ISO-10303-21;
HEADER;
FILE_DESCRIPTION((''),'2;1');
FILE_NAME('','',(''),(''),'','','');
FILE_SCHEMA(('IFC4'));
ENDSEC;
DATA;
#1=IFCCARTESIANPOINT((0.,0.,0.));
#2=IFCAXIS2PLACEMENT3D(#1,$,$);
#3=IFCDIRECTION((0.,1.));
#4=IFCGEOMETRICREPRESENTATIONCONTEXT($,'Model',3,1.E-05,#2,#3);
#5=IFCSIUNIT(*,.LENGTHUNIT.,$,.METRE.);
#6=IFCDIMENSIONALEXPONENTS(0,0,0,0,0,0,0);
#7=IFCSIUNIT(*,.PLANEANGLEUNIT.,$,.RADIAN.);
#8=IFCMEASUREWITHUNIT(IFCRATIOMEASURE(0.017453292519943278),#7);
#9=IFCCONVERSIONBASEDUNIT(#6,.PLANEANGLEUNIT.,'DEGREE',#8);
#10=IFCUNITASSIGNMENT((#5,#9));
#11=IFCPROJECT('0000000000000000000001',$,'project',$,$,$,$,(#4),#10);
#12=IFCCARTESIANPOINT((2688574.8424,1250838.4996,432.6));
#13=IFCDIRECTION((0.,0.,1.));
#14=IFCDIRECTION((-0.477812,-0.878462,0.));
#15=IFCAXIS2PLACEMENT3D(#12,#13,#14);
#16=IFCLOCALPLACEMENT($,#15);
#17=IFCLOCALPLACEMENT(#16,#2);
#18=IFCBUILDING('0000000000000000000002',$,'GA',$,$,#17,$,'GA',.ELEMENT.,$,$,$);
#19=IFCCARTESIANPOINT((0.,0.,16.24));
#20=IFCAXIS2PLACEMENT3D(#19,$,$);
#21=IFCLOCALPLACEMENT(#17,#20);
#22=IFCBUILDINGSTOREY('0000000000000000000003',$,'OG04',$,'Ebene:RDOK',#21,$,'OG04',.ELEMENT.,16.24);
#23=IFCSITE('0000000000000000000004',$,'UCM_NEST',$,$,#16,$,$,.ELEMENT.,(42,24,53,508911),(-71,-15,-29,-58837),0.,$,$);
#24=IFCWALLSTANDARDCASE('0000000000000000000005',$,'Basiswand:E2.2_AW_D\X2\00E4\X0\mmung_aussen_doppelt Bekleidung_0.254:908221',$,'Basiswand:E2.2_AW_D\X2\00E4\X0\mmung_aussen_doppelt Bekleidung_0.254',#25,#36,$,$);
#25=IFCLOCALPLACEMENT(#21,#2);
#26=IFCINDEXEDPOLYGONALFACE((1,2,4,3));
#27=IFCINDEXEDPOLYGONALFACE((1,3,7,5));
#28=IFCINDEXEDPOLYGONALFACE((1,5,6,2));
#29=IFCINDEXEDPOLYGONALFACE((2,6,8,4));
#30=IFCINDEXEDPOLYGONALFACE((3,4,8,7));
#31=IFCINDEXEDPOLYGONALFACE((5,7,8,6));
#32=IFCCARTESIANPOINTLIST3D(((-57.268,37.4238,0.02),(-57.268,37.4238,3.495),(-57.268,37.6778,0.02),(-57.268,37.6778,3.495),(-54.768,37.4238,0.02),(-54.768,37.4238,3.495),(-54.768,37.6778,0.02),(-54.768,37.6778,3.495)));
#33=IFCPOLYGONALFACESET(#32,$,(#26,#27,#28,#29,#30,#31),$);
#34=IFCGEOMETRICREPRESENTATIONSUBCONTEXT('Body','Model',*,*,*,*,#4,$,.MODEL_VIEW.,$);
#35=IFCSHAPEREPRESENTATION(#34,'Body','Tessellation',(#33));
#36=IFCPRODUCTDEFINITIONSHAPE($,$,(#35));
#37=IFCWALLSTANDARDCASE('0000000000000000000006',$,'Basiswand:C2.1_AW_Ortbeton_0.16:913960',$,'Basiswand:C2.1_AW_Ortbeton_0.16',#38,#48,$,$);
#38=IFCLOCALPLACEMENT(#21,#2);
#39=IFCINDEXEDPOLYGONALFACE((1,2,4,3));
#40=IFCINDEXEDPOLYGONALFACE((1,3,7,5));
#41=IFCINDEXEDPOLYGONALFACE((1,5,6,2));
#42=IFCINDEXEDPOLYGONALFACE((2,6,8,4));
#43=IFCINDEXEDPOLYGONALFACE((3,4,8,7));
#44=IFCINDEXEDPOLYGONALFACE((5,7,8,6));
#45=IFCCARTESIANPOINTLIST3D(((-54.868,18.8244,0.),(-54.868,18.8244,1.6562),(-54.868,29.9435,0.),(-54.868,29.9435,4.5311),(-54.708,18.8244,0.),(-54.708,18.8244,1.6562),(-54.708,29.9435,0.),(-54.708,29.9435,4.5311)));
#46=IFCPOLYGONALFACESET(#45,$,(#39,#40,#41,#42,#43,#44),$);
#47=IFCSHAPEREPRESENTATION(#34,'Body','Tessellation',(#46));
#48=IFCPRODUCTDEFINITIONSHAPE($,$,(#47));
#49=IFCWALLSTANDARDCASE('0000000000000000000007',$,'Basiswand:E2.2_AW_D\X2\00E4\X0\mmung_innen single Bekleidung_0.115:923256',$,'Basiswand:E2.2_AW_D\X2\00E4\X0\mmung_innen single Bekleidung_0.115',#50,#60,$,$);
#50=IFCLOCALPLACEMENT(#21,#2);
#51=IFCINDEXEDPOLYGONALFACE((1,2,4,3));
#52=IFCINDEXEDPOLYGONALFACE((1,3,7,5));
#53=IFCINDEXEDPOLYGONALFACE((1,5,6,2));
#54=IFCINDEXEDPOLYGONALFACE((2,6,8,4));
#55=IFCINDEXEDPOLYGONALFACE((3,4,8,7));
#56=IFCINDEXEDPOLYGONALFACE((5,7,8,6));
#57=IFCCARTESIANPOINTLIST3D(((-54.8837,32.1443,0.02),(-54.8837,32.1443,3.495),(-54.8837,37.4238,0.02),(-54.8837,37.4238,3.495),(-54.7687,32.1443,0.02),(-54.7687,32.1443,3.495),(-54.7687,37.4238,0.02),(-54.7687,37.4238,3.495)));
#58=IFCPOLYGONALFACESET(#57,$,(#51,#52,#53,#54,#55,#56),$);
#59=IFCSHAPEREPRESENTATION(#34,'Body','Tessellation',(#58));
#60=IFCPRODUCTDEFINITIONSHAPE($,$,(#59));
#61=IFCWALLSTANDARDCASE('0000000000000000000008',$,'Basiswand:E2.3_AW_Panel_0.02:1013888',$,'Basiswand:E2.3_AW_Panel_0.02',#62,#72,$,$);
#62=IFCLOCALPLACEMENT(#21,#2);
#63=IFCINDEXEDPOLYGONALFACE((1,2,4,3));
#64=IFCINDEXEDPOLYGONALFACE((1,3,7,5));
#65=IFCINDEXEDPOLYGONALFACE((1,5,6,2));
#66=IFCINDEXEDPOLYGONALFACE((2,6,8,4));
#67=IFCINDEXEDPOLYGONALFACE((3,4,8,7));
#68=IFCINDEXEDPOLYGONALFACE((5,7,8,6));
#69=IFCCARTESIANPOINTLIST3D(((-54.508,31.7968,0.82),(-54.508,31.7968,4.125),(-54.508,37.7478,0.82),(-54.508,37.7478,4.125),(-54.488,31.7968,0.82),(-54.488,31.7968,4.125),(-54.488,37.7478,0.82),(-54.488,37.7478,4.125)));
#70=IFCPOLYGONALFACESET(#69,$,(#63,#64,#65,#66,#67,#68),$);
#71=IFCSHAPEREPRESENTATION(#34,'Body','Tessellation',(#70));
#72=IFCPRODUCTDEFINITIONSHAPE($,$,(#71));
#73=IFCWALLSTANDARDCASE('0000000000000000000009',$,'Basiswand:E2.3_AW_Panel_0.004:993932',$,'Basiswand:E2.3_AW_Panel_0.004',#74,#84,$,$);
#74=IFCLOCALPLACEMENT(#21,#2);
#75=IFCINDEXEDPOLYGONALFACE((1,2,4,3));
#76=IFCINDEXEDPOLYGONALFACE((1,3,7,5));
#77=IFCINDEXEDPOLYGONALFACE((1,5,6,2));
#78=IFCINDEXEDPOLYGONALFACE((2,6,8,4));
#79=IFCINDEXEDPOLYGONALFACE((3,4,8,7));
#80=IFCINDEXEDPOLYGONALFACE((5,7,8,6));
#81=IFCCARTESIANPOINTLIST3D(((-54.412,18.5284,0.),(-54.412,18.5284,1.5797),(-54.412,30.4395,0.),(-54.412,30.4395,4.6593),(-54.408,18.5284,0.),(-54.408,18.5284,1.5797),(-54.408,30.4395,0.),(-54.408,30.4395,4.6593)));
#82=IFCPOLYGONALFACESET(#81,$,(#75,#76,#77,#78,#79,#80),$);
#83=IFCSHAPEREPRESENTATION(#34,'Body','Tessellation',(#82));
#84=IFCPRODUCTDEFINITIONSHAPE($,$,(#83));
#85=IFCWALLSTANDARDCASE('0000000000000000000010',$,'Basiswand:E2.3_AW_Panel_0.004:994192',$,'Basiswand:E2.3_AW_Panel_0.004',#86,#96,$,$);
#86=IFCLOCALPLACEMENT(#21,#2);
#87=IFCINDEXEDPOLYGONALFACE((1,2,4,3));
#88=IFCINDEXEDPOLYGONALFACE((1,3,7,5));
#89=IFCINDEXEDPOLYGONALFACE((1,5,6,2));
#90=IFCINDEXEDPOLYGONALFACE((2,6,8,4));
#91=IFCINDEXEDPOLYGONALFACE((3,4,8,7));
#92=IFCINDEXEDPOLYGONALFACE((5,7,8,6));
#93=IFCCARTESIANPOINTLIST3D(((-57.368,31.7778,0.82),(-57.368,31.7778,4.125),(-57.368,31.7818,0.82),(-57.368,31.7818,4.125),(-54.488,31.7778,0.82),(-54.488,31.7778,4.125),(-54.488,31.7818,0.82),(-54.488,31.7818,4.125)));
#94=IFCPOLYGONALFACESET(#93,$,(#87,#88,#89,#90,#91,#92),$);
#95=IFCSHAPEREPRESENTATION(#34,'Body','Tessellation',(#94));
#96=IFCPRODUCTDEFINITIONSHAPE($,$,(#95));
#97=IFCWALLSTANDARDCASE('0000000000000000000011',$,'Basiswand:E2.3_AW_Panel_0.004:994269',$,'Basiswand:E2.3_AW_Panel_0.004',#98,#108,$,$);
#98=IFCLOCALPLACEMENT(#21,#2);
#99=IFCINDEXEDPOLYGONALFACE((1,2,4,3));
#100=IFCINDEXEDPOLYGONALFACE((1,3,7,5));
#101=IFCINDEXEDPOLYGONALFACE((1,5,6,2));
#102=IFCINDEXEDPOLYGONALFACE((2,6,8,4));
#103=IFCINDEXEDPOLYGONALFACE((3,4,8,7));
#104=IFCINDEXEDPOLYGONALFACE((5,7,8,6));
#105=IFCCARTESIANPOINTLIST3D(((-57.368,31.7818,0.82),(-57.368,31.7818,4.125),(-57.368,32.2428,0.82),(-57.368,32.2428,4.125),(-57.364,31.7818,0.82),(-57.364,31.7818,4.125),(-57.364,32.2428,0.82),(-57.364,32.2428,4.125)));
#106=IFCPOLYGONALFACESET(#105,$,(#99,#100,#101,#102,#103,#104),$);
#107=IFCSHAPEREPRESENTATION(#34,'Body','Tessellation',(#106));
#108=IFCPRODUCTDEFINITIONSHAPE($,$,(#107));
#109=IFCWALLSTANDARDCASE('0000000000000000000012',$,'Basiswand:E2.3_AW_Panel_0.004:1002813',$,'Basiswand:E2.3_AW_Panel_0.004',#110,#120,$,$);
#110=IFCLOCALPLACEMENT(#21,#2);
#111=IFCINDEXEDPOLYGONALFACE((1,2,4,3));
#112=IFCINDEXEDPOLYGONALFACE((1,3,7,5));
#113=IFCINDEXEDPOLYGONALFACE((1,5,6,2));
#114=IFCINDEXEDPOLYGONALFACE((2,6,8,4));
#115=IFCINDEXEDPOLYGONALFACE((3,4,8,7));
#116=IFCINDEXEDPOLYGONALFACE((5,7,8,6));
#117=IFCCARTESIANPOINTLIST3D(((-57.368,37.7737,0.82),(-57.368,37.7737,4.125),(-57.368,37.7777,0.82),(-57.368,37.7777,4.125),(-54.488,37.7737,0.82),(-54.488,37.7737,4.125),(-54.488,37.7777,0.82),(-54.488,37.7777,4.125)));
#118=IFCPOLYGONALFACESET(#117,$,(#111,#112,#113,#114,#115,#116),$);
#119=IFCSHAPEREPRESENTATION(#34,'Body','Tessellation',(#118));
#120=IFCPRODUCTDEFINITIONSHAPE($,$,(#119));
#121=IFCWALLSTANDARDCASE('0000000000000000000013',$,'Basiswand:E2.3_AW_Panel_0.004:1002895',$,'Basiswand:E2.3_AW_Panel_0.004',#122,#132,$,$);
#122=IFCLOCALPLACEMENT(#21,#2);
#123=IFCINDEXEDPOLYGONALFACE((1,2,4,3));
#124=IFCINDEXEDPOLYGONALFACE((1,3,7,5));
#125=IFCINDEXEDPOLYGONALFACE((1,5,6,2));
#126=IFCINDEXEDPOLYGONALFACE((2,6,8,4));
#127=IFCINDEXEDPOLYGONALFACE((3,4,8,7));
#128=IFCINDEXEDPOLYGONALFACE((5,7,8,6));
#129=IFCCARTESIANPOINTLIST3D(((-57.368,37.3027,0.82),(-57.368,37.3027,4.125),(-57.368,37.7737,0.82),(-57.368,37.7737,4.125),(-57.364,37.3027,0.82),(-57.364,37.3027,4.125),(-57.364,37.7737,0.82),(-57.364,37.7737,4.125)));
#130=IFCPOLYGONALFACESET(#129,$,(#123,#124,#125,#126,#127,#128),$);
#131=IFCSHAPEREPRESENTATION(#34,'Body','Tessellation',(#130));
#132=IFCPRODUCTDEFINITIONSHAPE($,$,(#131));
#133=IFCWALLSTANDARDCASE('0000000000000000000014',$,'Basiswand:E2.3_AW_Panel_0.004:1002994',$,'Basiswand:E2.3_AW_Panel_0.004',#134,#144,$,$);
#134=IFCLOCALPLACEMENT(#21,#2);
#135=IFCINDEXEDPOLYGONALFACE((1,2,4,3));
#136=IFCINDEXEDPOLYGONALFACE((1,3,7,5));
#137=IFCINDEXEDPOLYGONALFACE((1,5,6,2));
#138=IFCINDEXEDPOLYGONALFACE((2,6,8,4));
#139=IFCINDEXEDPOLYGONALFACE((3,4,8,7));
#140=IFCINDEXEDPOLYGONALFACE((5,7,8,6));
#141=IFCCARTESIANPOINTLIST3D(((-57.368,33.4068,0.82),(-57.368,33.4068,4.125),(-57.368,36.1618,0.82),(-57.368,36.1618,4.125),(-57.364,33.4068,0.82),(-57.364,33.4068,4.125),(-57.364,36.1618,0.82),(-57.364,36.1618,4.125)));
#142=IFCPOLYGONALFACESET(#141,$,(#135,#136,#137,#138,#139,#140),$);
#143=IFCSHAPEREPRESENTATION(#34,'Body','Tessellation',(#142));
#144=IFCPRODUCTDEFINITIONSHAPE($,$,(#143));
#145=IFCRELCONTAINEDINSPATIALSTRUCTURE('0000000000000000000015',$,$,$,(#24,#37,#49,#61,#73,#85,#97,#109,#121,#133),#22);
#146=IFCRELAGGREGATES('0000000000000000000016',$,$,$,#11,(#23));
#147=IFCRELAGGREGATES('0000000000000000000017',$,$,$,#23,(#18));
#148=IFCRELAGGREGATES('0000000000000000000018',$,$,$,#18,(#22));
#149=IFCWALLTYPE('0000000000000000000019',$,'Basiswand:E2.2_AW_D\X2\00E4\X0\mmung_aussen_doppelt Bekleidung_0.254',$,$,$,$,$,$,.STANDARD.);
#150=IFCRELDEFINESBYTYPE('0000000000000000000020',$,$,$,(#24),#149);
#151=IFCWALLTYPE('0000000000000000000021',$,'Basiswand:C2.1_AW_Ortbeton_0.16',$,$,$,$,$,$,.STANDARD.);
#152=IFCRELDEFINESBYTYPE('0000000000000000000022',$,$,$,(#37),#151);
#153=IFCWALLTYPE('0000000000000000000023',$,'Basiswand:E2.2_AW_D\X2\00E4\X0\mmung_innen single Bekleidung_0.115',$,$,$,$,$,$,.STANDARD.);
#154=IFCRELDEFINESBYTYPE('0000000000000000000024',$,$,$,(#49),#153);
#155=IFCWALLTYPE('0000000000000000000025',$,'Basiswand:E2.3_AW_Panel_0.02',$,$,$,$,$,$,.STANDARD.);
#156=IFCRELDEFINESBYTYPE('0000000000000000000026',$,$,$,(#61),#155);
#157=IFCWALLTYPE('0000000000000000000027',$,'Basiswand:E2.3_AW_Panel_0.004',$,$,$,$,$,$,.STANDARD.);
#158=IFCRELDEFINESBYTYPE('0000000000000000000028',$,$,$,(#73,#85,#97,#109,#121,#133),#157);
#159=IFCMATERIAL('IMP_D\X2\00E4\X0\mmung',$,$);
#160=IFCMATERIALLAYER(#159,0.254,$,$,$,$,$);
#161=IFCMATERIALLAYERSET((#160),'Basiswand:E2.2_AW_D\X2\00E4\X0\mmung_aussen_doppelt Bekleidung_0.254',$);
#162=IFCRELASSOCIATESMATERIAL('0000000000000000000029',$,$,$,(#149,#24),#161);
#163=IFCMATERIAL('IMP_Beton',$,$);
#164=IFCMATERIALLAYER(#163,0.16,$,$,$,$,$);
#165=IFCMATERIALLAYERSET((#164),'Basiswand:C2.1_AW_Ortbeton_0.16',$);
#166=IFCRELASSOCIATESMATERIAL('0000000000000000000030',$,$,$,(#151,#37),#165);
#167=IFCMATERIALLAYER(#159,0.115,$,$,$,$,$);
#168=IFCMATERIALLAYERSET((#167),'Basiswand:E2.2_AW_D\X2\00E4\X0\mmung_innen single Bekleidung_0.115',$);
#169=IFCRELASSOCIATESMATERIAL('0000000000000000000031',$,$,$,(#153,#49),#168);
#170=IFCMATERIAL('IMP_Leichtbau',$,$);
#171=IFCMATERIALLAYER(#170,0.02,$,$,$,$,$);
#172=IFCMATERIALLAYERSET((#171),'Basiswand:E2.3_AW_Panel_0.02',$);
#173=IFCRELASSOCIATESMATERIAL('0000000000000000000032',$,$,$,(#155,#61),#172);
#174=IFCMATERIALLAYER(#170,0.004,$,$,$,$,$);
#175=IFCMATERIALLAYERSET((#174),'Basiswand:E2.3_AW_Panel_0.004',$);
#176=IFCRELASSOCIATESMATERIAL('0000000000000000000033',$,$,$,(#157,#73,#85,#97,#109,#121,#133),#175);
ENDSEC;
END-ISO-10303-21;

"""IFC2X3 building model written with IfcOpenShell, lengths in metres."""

from ifc_helpers import new_model, entity, si_unit, converted_unit, direction, frame, frame_2d, origin, place, context, subcontext, project, spatial, rectangle, extrude, clip, halfspace, material, layer, layer_set, layer_usage, type_object, element, save


model = new_model("IFC2X3")

# Units and contexts
model_context = context("Model", 3, precision=1e-05, world=origin(), true_north=direction((0.0, 1.0)))
body_context = subcontext(model_context, "Body", "Model", "MODEL_VIEW")
ifc_project = project(units=[si_unit("LENGTHUNIT", "METRE"), converted_unit("PLANEANGLEUNIT", "DEGREE", entity("IfcRatioMeasure", 0.017453292519943278), si_unit("PLANEANGLEUNIT", "RADIAN"), dimensions=[0, 0, 0, 0, 0, 0, 0])], contexts=[model_context])

# Site, building, storey
site_placement = place(None, frame((2688574.8424, 1250838.4996, 432.6), z_axis=(0.0, 0.0, 1.0), x_axis=(-0.477812, -0.878462, 0.0)))
site = spatial("IfcSite", under=ifc_project, at=site_placement, Name="UCM_NEST", CompositionType="ELEMENT", RefLatitude=(42, 24, 53, 508911), RefLongitude=(-71, -15, -29, -58837), RefElevation=0.0)
building_placement = place(site_placement, origin())
building = spatial("IfcBuilding", under=site, at=building_placement, Name="GA", LongName="GA", CompositionType="ELEMENT")
storey_placement = place(building_placement, frame((0.0, 0.0, 16.24)))
storey = spatial("IfcBuildingStorey", under=building, at=storey_placement, Name="OG04", ObjectType="Ebene:RDOK", LongName="OG04", CompositionType="ELEMENT", Elevation=16.24)

# Shared definitions
ifc_material_1 = material(Name="IMP_Dämmung")

# Walls
ifc_layer_1 = layer(ifc_material_1, 0.254)
ifc_layer_set_1 = layer_set([ifc_layer_1], Name="Basiswand:E2.2_AW_Dämmung_aussen_doppelt Bekleidung_0.254")
ifc_layer_usage_1 = layer_usage(ifc_layer_set_1, "AXIS2", "NEGATIVE", 0.127)
wall_type_1 = type_object("IfcWallType", Name="Basiswand:E2.2_AW_Dämmung_aussen_doppelt Bekleidung_0.254", PredefinedType="STANDARD", material=ifc_layer_set_1)
wall_1_placement = place(storey_placement, frame((-57.268, 37.5508, 0.02)))
element("IfcWallStandardCase", 1, at=wall_1_placement, inside=storey, type_object=wall_type_1, material=ifc_layer_usage_1, Name="Basiswand:E2.2_AW_Dämmung_aussen_doppelt Bekleidung_0.254:908221", ObjectType="Basiswand:E2.2_AW_Dämmung_aussen_doppelt Bekleidung_0.254", context=body_context, shape_type="SweptSolid", body=[
    extrude(rectangle(XDim=2.5, YDim=0.254, at=frame_2d((1.25, 0.0), x_axis=(-1.0, 0.0))), origin(), (0.0, 0.0, 1.0), 3.475),
])
ifc_material_2 = material(Name="IMP_Beton")
ifc_layer_2 = layer(ifc_material_2, 0.16)
ifc_layer_set_2 = layer_set([ifc_layer_2], Name="Basiswand:C2.1_AW_Ortbeton_0.16")
ifc_layer_usage_2 = layer_usage(ifc_layer_set_2, "AXIS2", "NEGATIVE", 0.08)
wall_type_2 = type_object("IfcWallType", Name="Basiswand:C2.1_AW_Ortbeton_0.16", PredefinedType="STANDARD", material=ifc_layer_set_2)
wall_2_placement = place(storey_placement, frame((-54.788, 29.9435, 0.0), z_axis=(0.0, 0.0, 1.0), x_axis=(0.0, -1.0, 0.0)))
element("IfcWallStandardCase", 2, at=wall_2_placement, inside=storey, type_object=wall_type_2, material=ifc_layer_usage_2, Name="Basiswand:C2.1_AW_Ortbeton_0.16:913960", ObjectType="Basiswand:C2.1_AW_Ortbeton_0.16", context=body_context, shape_type="Clipping", body=[
    clip(extrude(rectangle(XDim=11.119, YDim=0.16, at=frame_2d((5.5595, 0.0), x_axis=(-1.0, 0.0))), origin(), (0.0, 0.0, 1.0), 4.5311), halfspace(frame((0.0, -0.08, 4.5311), z_axis=(0.250322, 0.0, 0.968163), x_axis=(0.0, 1.0, 0.0)), False)),
])
ifc_layer_3 = layer(ifc_material_1, 0.115)
ifc_layer_set_3 = layer_set([ifc_layer_3], Name="Basiswand:E2.2_AW_Dämmung_innen single Bekleidung_0.115")
ifc_layer_usage_3 = layer_usage(ifc_layer_set_3, "AXIS2", "NEGATIVE", 0.0575)
wall_type_3 = type_object("IfcWallType", Name="Basiswand:E2.2_AW_Dämmung_innen single Bekleidung_0.115", PredefinedType="STANDARD", material=ifc_layer_set_3)
wall_3_placement = place(storey_placement, frame((-54.8262, 37.4238, 0.02), z_axis=(0.0, 0.0, 1.0), x_axis=(0.0, -1.0, 0.0)))
element("IfcWallStandardCase", 3, at=wall_3_placement, inside=storey, type_object=wall_type_3, material=ifc_layer_usage_3, Name="Basiswand:E2.2_AW_Dämmung_innen single Bekleidung_0.115:923256", ObjectType="Basiswand:E2.2_AW_Dämmung_innen single Bekleidung_0.115", context=body_context, shape_type="SweptSolid", body=[
    extrude(rectangle(XDim=5.2795, YDim=0.115, at=frame_2d((2.6397, 0.0), x_axis=(-1.0, 0.0))), origin(), (0.0, 0.0, 1.0), 3.475),
])
ifc_material_3 = material(Name="IMP_Leichtbau")
ifc_layer_4 = layer(ifc_material_3, 0.02)
ifc_layer_set_4 = layer_set([ifc_layer_4], Name="Basiswand:E2.3_AW_Panel_0.02")
ifc_layer_usage_4 = layer_usage(ifc_layer_set_4, "AXIS2", "NEGATIVE", 0.01)
wall_type_4 = type_object("IfcWallType", Name="Basiswand:E2.3_AW_Panel_0.02", PredefinedType="STANDARD", material=ifc_layer_set_4)
wall_4_placement = place(storey_placement, frame((-54.498, 37.7478, 0.82), z_axis=(0.0, 0.0, 1.0), x_axis=(0.0, -1.0, 0.0)))
element("IfcWallStandardCase", 4, at=wall_4_placement, inside=storey, type_object=wall_type_4, material=ifc_layer_usage_4, Name="Basiswand:E2.3_AW_Panel_0.02:1013888", ObjectType="Basiswand:E2.3_AW_Panel_0.02", context=body_context, shape_type="SweptSolid", body=[
    extrude(rectangle(XDim=5.951, YDim=0.02, at=frame_2d((2.9755, 0.0), x_axis=(-1.0, 0.0))), origin(), (0.0, 0.0, 1.0), 3.305),
])
ifc_layer_5 = layer(ifc_material_3, 0.004)
ifc_layer_set_5 = layer_set([ifc_layer_5], Name="Basiswand:E2.3_AW_Panel_0.004")
ifc_layer_usage_5 = layer_usage(ifc_layer_set_5, "AXIS2", "NEGATIVE", 0.002)
wall_type_5 = type_object("IfcWallType", Name="Basiswand:E2.3_AW_Panel_0.004", PredefinedType="STANDARD", material=ifc_layer_set_5)
wall_5_placement = place(storey_placement, frame((-54.41, 30.4395, 0.0), z_axis=(0.0, 0.0, 1.0), x_axis=(0.0, -1.0, 0.0)))
element("IfcWallStandardCase", 5, at=wall_5_placement, inside=storey, type_object=wall_type_5, material=ifc_layer_usage_5, Name="Basiswand:E2.3_AW_Panel_0.004:993932", ObjectType="Basiswand:E2.3_AW_Panel_0.004", context=body_context, shape_type="Clipping", body=[
    clip(extrude(rectangle(XDim=11.911, YDim=0.004, at=frame_2d((5.9555, 0.0), x_axis=(-1.0, 0.0))), origin(), (0.0, 0.0, 1.0), 4.6593), halfspace(frame((0.0, -0.002, 4.6593), z_axis=(0.250322, 0.0, 0.968163), x_axis=(0.0, 1.0, 0.0)), False)),
])
wall_6_placement = place(storey_placement, frame((-54.488, 31.7798, 0.82), z_axis=(0.0, 0.0, 1.0), x_axis=(-1.0, 0.0, 0.0)))
element("IfcWallStandardCase", 6, at=wall_6_placement, inside=storey, type_object=wall_type_5, material=ifc_layer_usage_5, Name="Basiswand:E2.3_AW_Panel_0.004:994192", ObjectType="Basiswand:E2.3_AW_Panel_0.004", context=body_context, shape_type="SweptSolid", body=[
    extrude(rectangle(XDim=2.88, YDim=0.004, at=frame_2d((1.44, 0.0), x_axis=(-1.0, 0.0))), origin(), (0.0, 0.0, 1.0), 3.305),
])
wall_7_placement = place(storey_placement, frame((-57.366, 31.7818, 0.82), z_axis=(0.0, 0.0, 1.0), x_axis=(0.0, 1.0, 0.0)))
element("IfcWallStandardCase", 7, at=wall_7_placement, inside=storey, type_object=wall_type_5, material=ifc_layer_usage_5, Name="Basiswand:E2.3_AW_Panel_0.004:994269", ObjectType="Basiswand:E2.3_AW_Panel_0.004", context=body_context, shape_type="SweptSolid", body=[
    extrude(rectangle(XDim=0.461, YDim=0.004, at=frame_2d((0.2305, 0.0), x_axis=(-1.0, 0.0))), origin(), (0.0, 0.0, 1.0), 3.305),
])
wall_8_placement = place(storey_placement, frame((-54.488, 37.7757, 0.82), z_axis=(0.0, 0.0, 1.0), x_axis=(-1.0, 0.0, 0.0)))
element("IfcWallStandardCase", 8, at=wall_8_placement, inside=storey, type_object=wall_type_5, material=ifc_layer_usage_5, Name="Basiswand:E2.3_AW_Panel_0.004:1002813", ObjectType="Basiswand:E2.3_AW_Panel_0.004", context=body_context, shape_type="SweptSolid", body=[
    extrude(rectangle(XDim=2.88, YDim=0.004, at=frame_2d((1.44, 0.0), x_axis=(-1.0, 0.0))), origin(), (0.0, 0.0, 1.0), 3.305),
])
wall_9_placement = place(storey_placement, frame((-57.366, 37.7737, 0.82), z_axis=(0.0, 0.0, 1.0), x_axis=(0.0, -1.0, 0.0)))
element("IfcWallStandardCase", 9, at=wall_9_placement, inside=storey, type_object=wall_type_5, material=ifc_layer_usage_5, Name="Basiswand:E2.3_AW_Panel_0.004:1002895", ObjectType="Basiswand:E2.3_AW_Panel_0.004", context=body_context, shape_type="SweptSolid", body=[
    extrude(rectangle(XDim=0.471, YDim=0.004, at=frame_2d((0.2355, 0.0), x_axis=(-1.0, 0.0))), origin(), (0.0, 0.0, 1.0), 3.305),
])
wall_10_placement = place(storey_placement, frame((-57.366, 36.1618, 0.82), z_axis=(0.0, 0.0, 1.0), x_axis=(0.0, -1.0, 0.0)))
element("IfcWallStandardCase", 10, at=wall_10_placement, inside=storey, type_object=wall_type_5, material=ifc_layer_usage_5, Name="Basiswand:E2.3_AW_Panel_0.004:1002994", ObjectType="Basiswand:E2.3_AW_Panel_0.004", context=body_context, shape_type="SweptSolid", body=[
    extrude(rectangle(XDim=2.755, YDim=0.004, at=frame_2d((1.3775, 0.0), x_axis=(-1.0, 0.0))), origin(), (0.0, 0.0, 1.0), 3.305),
])

save(model, "model.ifc")
